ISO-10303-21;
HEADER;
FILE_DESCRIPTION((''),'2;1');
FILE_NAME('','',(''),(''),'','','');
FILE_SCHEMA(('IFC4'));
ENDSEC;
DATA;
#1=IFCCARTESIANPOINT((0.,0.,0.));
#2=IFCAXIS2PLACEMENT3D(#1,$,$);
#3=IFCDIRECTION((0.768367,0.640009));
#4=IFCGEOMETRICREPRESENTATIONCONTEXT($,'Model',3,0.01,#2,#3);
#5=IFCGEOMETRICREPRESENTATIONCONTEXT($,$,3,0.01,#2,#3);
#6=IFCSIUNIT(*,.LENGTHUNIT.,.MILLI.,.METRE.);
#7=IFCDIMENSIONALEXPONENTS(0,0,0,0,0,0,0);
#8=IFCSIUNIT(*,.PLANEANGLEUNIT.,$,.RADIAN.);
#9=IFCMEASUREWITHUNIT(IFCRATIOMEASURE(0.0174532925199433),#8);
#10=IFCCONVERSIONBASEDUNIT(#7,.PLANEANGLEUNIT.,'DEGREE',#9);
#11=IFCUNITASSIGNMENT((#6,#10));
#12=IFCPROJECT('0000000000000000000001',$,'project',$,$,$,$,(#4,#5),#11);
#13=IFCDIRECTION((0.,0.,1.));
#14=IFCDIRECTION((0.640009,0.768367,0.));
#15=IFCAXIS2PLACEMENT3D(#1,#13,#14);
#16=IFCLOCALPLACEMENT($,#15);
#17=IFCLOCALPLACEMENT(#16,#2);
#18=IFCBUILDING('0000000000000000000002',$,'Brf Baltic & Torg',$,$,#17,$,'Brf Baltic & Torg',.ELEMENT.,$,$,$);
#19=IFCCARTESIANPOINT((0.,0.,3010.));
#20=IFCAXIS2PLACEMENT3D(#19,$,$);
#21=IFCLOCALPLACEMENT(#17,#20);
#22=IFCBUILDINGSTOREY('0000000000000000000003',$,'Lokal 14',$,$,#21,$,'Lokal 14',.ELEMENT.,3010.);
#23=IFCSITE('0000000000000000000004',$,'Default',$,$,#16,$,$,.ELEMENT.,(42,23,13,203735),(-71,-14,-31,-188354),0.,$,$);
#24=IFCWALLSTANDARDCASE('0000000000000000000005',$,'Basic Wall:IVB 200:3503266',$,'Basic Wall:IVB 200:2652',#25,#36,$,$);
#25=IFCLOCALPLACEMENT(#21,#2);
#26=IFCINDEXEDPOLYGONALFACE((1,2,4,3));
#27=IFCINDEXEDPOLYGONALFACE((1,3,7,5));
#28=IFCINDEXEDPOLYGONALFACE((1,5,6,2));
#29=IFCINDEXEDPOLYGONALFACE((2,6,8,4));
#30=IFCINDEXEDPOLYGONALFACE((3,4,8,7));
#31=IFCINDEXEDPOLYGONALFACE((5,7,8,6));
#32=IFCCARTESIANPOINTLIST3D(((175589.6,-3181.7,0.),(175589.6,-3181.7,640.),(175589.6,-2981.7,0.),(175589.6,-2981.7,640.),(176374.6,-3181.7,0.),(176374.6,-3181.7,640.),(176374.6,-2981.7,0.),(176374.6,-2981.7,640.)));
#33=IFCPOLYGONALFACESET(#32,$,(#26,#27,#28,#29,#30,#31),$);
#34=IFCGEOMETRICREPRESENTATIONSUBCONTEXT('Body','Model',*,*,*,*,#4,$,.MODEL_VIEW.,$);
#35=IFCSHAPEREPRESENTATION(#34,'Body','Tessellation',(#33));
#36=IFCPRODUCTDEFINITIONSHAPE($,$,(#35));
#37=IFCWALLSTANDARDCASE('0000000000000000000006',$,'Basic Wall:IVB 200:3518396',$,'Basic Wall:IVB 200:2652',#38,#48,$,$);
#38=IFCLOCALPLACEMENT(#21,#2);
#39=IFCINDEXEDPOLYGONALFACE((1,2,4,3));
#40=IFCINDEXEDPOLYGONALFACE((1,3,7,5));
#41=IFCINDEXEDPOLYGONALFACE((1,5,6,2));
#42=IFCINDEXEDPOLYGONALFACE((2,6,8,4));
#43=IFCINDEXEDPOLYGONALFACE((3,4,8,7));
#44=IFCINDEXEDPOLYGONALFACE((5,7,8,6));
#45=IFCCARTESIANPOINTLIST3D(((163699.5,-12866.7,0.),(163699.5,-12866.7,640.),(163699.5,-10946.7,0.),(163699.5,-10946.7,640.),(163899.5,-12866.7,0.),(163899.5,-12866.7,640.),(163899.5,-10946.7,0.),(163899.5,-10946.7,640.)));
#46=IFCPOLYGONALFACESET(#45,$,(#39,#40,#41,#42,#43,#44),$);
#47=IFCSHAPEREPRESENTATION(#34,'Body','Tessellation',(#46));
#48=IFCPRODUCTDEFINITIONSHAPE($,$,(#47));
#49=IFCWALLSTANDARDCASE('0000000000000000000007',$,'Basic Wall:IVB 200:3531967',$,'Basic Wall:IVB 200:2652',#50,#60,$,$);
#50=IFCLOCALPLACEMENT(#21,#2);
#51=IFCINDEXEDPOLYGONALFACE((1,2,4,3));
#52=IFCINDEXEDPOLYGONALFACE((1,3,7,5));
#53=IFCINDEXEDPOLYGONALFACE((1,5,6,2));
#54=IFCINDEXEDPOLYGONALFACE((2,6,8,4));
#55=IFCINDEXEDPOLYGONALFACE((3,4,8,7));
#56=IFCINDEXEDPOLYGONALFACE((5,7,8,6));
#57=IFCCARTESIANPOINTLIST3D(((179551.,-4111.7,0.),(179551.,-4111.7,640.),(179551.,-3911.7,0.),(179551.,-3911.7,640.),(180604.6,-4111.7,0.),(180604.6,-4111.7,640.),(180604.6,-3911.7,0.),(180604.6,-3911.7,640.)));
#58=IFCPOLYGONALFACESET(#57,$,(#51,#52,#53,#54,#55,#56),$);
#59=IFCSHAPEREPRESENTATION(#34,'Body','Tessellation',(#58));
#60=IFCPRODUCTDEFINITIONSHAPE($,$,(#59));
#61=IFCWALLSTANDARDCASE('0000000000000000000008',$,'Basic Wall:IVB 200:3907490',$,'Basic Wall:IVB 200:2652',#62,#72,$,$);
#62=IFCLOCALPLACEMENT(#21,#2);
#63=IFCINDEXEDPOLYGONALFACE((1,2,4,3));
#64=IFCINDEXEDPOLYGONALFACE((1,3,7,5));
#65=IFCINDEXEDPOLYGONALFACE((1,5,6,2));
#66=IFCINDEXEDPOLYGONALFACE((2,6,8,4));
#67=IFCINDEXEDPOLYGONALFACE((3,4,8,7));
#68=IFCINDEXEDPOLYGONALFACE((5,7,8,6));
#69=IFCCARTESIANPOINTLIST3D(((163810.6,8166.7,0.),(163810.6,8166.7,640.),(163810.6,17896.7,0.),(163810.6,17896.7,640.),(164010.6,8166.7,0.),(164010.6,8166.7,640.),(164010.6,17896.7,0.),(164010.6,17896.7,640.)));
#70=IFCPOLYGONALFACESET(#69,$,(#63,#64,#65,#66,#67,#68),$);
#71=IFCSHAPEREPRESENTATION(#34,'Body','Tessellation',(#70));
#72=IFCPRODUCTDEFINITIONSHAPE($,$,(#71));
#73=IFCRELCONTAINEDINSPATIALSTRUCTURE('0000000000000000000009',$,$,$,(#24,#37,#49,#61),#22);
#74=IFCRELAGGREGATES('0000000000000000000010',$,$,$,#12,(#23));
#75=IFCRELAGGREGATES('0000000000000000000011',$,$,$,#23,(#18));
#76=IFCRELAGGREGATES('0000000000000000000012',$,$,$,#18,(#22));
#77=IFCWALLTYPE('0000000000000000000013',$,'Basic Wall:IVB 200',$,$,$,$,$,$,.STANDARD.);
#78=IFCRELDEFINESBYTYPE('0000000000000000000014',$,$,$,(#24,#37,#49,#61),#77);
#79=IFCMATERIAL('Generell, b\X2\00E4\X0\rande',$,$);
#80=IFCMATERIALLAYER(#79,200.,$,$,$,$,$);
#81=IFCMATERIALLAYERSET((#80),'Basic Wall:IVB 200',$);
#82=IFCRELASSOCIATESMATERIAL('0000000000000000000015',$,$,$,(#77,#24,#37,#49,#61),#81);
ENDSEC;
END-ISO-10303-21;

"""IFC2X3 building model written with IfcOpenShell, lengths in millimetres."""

from ifc_helpers import new_model, entity, si_unit, converted_unit, direction, frame, frame_2d, origin, place, context, subcontext, project, spatial, rectangle, extrude, clip, halfspace, material, layer, layer_set, layer_usage, type_object, element, save


model = new_model("IFC2X3")

# Units and contexts
model_context = context("Model", 3, precision=0.01, world=origin(), true_north=direction((0.768367, 0.640009)))
context_of_model = context(None, 3, precision=0.01, world=origin(), true_north=direction((0.768367, 0.640009)))
body_context = subcontext(model_context, "Body", "Model", "MODEL_VIEW")
ifc_project = project(units=[si_unit("LENGTHUNIT", "METRE", prefix="MILLI"), converted_unit("PLANEANGLEUNIT", "DEGREE", entity("IfcRatioMeasure", 0.0174532925199433), si_unit("PLANEANGLEUNIT", "RADIAN"), dimensions=[0, 0, 0, 0, 0, 0, 0])], contexts=[model_context, context_of_model])

# Site, building, storey
site_placement = place(None, frame((0.0, 0.0, 0.0), z_axis=(0.0, 0.0, 1.0), x_axis=(0.640009, 0.768367, 0.0)))
site = spatial("IfcSite", under=ifc_project, at=site_placement, Name="Default", CompositionType="ELEMENT", RefLatitude=(42, 23, 13, 203735), RefLongitude=(-71, -14, -31, -188354), RefElevation=0.0)
building_placement = place(site_placement, origin())
building = spatial("IfcBuilding", under=site, at=building_placement, Name="Brf Baltic & Torg", LongName="Brf Baltic & Torg", CompositionType="ELEMENT")
storey_placement = place(building_placement, frame((0.0, 0.0, 3010.0)))
storey = spatial("IfcBuildingStorey", under=building, at=storey_placement, Name="Lokal 14", LongName="Lokal 14", CompositionType="ELEMENT", Elevation=3010.0)

# Shared definitions
ifc_material_1 = material(Name="Generell, bärande")
ifc_layer = layer(ifc_material_1, 200.0)
ifc_layer_set = layer_set([ifc_layer], Name="Basic Wall:IVB 200")
wall_type = type_object("IfcWallType", Name="Basic Wall:IVB 200", PredefinedType="STANDARD", material=ifc_layer_set)

# Walls
ifc_layer_usage_1 = layer_usage(ifc_layer_set, "AXIS2", "NEGATIVE", 100.0)
wall_1_placement = place(storey_placement, frame((175589.6, -3081.7, 0.0)))
element("IfcWallStandardCase", 1, at=wall_1_placement, inside=storey, type_object=wall_type, material=ifc_layer_usage_1, Name="Basic Wall:IVB 200:3503266", ObjectType="Basic Wall:IVB 200:2652", context=body_context, shape_type="Clipping", body=[
    clip(extrude(rectangle(XDim=785.0, YDim=200.0, at=frame_2d((392.5, 0.0), x_axis=(-1.0, 0.0))), origin(), (0.0, 0.0, 1.0), 640.0), halfspace(frame((0.0, 0.0, -1360.0)), True)),
])
ifc_layer_usage_2 = layer_usage(ifc_layer_set, "AXIS2", "POSITIVE", -100.0)
wall_2_placement = place(storey_placement, frame((163799.5, -10946.7, 0.0), z_axis=(0.0, 0.0, 1.0), x_axis=(0.0, -1.0, 0.0)))
element("IfcWallStandardCase", 2, at=wall_2_placement, inside=storey, type_object=wall_type, material=ifc_layer_usage_2, Name="Basic Wall:IVB 200:3518396", ObjectType="Basic Wall:IVB 200:2652", context=body_context, shape_type="Clipping", body=[
    clip(extrude(rectangle(XDim=1920.0, YDim=200.0, at=frame_2d((960.0, 0.0), x_axis=(-1.0, 0.0))), origin(), (0.0, 0.0, 1.0), 640.0), halfspace(frame((0.0, 0.0, -1360.0)), True)),
])
ifc_layer_usage_3 = layer_usage(ifc_layer_set, "AXIS2", "NEGATIVE", 100.0)
wall_3_placement = place(storey_placement, frame((179551.0, -4011.7, 0.0)))
element("IfcWallStandardCase", 3, at=wall_3_placement, inside=storey, type_object=wall_type, material=ifc_layer_usage_3, Name="Basic Wall:IVB 200:3531967", ObjectType="Basic Wall:IVB 200:2652", context=body_context, shape_type="Clipping", body=[
    clip(extrude(rectangle(XDim=1053.6, YDim=200.0, at=frame_2d((526.8, 0.0), x_axis=(-1.0, 0.0))), origin(), (0.0, 0.0, 1.0), 640.0), halfspace(frame((0.0, 0.0, -1360.0)), True)),
])

# Wall
ifc_layer_usage_4 = layer_usage(ifc_layer_set, "AXIS2", "NEGATIVE", 100.0)
wall_4_placement = place(storey_placement, frame((163910.6, 8166.7, 0.0), z_axis=(0.0, 0.0, 1.0), x_axis=(0.0, 1.0, 0.0)))
element("IfcWallStandardCase", 4, at=wall_4_placement, inside=storey, type_object=wall_type, material=ifc_layer_usage_4, Name="Basic Wall:IVB 200:3907490", ObjectType="Basic Wall:IVB 200:2652", context=body_context, shape_type="Clipping", body=[
    clip(extrude(rectangle(XDim=9730.0, YDim=200.0, at=frame_2d((4865.0, 0.0), x_axis=(-1.0, 0.0))), origin(), (0.0, 0.0, 1.0), 640.0), halfspace(frame((0.0, 0.0, -1360.0)), True)),
])

save(model, "model.ifc")
